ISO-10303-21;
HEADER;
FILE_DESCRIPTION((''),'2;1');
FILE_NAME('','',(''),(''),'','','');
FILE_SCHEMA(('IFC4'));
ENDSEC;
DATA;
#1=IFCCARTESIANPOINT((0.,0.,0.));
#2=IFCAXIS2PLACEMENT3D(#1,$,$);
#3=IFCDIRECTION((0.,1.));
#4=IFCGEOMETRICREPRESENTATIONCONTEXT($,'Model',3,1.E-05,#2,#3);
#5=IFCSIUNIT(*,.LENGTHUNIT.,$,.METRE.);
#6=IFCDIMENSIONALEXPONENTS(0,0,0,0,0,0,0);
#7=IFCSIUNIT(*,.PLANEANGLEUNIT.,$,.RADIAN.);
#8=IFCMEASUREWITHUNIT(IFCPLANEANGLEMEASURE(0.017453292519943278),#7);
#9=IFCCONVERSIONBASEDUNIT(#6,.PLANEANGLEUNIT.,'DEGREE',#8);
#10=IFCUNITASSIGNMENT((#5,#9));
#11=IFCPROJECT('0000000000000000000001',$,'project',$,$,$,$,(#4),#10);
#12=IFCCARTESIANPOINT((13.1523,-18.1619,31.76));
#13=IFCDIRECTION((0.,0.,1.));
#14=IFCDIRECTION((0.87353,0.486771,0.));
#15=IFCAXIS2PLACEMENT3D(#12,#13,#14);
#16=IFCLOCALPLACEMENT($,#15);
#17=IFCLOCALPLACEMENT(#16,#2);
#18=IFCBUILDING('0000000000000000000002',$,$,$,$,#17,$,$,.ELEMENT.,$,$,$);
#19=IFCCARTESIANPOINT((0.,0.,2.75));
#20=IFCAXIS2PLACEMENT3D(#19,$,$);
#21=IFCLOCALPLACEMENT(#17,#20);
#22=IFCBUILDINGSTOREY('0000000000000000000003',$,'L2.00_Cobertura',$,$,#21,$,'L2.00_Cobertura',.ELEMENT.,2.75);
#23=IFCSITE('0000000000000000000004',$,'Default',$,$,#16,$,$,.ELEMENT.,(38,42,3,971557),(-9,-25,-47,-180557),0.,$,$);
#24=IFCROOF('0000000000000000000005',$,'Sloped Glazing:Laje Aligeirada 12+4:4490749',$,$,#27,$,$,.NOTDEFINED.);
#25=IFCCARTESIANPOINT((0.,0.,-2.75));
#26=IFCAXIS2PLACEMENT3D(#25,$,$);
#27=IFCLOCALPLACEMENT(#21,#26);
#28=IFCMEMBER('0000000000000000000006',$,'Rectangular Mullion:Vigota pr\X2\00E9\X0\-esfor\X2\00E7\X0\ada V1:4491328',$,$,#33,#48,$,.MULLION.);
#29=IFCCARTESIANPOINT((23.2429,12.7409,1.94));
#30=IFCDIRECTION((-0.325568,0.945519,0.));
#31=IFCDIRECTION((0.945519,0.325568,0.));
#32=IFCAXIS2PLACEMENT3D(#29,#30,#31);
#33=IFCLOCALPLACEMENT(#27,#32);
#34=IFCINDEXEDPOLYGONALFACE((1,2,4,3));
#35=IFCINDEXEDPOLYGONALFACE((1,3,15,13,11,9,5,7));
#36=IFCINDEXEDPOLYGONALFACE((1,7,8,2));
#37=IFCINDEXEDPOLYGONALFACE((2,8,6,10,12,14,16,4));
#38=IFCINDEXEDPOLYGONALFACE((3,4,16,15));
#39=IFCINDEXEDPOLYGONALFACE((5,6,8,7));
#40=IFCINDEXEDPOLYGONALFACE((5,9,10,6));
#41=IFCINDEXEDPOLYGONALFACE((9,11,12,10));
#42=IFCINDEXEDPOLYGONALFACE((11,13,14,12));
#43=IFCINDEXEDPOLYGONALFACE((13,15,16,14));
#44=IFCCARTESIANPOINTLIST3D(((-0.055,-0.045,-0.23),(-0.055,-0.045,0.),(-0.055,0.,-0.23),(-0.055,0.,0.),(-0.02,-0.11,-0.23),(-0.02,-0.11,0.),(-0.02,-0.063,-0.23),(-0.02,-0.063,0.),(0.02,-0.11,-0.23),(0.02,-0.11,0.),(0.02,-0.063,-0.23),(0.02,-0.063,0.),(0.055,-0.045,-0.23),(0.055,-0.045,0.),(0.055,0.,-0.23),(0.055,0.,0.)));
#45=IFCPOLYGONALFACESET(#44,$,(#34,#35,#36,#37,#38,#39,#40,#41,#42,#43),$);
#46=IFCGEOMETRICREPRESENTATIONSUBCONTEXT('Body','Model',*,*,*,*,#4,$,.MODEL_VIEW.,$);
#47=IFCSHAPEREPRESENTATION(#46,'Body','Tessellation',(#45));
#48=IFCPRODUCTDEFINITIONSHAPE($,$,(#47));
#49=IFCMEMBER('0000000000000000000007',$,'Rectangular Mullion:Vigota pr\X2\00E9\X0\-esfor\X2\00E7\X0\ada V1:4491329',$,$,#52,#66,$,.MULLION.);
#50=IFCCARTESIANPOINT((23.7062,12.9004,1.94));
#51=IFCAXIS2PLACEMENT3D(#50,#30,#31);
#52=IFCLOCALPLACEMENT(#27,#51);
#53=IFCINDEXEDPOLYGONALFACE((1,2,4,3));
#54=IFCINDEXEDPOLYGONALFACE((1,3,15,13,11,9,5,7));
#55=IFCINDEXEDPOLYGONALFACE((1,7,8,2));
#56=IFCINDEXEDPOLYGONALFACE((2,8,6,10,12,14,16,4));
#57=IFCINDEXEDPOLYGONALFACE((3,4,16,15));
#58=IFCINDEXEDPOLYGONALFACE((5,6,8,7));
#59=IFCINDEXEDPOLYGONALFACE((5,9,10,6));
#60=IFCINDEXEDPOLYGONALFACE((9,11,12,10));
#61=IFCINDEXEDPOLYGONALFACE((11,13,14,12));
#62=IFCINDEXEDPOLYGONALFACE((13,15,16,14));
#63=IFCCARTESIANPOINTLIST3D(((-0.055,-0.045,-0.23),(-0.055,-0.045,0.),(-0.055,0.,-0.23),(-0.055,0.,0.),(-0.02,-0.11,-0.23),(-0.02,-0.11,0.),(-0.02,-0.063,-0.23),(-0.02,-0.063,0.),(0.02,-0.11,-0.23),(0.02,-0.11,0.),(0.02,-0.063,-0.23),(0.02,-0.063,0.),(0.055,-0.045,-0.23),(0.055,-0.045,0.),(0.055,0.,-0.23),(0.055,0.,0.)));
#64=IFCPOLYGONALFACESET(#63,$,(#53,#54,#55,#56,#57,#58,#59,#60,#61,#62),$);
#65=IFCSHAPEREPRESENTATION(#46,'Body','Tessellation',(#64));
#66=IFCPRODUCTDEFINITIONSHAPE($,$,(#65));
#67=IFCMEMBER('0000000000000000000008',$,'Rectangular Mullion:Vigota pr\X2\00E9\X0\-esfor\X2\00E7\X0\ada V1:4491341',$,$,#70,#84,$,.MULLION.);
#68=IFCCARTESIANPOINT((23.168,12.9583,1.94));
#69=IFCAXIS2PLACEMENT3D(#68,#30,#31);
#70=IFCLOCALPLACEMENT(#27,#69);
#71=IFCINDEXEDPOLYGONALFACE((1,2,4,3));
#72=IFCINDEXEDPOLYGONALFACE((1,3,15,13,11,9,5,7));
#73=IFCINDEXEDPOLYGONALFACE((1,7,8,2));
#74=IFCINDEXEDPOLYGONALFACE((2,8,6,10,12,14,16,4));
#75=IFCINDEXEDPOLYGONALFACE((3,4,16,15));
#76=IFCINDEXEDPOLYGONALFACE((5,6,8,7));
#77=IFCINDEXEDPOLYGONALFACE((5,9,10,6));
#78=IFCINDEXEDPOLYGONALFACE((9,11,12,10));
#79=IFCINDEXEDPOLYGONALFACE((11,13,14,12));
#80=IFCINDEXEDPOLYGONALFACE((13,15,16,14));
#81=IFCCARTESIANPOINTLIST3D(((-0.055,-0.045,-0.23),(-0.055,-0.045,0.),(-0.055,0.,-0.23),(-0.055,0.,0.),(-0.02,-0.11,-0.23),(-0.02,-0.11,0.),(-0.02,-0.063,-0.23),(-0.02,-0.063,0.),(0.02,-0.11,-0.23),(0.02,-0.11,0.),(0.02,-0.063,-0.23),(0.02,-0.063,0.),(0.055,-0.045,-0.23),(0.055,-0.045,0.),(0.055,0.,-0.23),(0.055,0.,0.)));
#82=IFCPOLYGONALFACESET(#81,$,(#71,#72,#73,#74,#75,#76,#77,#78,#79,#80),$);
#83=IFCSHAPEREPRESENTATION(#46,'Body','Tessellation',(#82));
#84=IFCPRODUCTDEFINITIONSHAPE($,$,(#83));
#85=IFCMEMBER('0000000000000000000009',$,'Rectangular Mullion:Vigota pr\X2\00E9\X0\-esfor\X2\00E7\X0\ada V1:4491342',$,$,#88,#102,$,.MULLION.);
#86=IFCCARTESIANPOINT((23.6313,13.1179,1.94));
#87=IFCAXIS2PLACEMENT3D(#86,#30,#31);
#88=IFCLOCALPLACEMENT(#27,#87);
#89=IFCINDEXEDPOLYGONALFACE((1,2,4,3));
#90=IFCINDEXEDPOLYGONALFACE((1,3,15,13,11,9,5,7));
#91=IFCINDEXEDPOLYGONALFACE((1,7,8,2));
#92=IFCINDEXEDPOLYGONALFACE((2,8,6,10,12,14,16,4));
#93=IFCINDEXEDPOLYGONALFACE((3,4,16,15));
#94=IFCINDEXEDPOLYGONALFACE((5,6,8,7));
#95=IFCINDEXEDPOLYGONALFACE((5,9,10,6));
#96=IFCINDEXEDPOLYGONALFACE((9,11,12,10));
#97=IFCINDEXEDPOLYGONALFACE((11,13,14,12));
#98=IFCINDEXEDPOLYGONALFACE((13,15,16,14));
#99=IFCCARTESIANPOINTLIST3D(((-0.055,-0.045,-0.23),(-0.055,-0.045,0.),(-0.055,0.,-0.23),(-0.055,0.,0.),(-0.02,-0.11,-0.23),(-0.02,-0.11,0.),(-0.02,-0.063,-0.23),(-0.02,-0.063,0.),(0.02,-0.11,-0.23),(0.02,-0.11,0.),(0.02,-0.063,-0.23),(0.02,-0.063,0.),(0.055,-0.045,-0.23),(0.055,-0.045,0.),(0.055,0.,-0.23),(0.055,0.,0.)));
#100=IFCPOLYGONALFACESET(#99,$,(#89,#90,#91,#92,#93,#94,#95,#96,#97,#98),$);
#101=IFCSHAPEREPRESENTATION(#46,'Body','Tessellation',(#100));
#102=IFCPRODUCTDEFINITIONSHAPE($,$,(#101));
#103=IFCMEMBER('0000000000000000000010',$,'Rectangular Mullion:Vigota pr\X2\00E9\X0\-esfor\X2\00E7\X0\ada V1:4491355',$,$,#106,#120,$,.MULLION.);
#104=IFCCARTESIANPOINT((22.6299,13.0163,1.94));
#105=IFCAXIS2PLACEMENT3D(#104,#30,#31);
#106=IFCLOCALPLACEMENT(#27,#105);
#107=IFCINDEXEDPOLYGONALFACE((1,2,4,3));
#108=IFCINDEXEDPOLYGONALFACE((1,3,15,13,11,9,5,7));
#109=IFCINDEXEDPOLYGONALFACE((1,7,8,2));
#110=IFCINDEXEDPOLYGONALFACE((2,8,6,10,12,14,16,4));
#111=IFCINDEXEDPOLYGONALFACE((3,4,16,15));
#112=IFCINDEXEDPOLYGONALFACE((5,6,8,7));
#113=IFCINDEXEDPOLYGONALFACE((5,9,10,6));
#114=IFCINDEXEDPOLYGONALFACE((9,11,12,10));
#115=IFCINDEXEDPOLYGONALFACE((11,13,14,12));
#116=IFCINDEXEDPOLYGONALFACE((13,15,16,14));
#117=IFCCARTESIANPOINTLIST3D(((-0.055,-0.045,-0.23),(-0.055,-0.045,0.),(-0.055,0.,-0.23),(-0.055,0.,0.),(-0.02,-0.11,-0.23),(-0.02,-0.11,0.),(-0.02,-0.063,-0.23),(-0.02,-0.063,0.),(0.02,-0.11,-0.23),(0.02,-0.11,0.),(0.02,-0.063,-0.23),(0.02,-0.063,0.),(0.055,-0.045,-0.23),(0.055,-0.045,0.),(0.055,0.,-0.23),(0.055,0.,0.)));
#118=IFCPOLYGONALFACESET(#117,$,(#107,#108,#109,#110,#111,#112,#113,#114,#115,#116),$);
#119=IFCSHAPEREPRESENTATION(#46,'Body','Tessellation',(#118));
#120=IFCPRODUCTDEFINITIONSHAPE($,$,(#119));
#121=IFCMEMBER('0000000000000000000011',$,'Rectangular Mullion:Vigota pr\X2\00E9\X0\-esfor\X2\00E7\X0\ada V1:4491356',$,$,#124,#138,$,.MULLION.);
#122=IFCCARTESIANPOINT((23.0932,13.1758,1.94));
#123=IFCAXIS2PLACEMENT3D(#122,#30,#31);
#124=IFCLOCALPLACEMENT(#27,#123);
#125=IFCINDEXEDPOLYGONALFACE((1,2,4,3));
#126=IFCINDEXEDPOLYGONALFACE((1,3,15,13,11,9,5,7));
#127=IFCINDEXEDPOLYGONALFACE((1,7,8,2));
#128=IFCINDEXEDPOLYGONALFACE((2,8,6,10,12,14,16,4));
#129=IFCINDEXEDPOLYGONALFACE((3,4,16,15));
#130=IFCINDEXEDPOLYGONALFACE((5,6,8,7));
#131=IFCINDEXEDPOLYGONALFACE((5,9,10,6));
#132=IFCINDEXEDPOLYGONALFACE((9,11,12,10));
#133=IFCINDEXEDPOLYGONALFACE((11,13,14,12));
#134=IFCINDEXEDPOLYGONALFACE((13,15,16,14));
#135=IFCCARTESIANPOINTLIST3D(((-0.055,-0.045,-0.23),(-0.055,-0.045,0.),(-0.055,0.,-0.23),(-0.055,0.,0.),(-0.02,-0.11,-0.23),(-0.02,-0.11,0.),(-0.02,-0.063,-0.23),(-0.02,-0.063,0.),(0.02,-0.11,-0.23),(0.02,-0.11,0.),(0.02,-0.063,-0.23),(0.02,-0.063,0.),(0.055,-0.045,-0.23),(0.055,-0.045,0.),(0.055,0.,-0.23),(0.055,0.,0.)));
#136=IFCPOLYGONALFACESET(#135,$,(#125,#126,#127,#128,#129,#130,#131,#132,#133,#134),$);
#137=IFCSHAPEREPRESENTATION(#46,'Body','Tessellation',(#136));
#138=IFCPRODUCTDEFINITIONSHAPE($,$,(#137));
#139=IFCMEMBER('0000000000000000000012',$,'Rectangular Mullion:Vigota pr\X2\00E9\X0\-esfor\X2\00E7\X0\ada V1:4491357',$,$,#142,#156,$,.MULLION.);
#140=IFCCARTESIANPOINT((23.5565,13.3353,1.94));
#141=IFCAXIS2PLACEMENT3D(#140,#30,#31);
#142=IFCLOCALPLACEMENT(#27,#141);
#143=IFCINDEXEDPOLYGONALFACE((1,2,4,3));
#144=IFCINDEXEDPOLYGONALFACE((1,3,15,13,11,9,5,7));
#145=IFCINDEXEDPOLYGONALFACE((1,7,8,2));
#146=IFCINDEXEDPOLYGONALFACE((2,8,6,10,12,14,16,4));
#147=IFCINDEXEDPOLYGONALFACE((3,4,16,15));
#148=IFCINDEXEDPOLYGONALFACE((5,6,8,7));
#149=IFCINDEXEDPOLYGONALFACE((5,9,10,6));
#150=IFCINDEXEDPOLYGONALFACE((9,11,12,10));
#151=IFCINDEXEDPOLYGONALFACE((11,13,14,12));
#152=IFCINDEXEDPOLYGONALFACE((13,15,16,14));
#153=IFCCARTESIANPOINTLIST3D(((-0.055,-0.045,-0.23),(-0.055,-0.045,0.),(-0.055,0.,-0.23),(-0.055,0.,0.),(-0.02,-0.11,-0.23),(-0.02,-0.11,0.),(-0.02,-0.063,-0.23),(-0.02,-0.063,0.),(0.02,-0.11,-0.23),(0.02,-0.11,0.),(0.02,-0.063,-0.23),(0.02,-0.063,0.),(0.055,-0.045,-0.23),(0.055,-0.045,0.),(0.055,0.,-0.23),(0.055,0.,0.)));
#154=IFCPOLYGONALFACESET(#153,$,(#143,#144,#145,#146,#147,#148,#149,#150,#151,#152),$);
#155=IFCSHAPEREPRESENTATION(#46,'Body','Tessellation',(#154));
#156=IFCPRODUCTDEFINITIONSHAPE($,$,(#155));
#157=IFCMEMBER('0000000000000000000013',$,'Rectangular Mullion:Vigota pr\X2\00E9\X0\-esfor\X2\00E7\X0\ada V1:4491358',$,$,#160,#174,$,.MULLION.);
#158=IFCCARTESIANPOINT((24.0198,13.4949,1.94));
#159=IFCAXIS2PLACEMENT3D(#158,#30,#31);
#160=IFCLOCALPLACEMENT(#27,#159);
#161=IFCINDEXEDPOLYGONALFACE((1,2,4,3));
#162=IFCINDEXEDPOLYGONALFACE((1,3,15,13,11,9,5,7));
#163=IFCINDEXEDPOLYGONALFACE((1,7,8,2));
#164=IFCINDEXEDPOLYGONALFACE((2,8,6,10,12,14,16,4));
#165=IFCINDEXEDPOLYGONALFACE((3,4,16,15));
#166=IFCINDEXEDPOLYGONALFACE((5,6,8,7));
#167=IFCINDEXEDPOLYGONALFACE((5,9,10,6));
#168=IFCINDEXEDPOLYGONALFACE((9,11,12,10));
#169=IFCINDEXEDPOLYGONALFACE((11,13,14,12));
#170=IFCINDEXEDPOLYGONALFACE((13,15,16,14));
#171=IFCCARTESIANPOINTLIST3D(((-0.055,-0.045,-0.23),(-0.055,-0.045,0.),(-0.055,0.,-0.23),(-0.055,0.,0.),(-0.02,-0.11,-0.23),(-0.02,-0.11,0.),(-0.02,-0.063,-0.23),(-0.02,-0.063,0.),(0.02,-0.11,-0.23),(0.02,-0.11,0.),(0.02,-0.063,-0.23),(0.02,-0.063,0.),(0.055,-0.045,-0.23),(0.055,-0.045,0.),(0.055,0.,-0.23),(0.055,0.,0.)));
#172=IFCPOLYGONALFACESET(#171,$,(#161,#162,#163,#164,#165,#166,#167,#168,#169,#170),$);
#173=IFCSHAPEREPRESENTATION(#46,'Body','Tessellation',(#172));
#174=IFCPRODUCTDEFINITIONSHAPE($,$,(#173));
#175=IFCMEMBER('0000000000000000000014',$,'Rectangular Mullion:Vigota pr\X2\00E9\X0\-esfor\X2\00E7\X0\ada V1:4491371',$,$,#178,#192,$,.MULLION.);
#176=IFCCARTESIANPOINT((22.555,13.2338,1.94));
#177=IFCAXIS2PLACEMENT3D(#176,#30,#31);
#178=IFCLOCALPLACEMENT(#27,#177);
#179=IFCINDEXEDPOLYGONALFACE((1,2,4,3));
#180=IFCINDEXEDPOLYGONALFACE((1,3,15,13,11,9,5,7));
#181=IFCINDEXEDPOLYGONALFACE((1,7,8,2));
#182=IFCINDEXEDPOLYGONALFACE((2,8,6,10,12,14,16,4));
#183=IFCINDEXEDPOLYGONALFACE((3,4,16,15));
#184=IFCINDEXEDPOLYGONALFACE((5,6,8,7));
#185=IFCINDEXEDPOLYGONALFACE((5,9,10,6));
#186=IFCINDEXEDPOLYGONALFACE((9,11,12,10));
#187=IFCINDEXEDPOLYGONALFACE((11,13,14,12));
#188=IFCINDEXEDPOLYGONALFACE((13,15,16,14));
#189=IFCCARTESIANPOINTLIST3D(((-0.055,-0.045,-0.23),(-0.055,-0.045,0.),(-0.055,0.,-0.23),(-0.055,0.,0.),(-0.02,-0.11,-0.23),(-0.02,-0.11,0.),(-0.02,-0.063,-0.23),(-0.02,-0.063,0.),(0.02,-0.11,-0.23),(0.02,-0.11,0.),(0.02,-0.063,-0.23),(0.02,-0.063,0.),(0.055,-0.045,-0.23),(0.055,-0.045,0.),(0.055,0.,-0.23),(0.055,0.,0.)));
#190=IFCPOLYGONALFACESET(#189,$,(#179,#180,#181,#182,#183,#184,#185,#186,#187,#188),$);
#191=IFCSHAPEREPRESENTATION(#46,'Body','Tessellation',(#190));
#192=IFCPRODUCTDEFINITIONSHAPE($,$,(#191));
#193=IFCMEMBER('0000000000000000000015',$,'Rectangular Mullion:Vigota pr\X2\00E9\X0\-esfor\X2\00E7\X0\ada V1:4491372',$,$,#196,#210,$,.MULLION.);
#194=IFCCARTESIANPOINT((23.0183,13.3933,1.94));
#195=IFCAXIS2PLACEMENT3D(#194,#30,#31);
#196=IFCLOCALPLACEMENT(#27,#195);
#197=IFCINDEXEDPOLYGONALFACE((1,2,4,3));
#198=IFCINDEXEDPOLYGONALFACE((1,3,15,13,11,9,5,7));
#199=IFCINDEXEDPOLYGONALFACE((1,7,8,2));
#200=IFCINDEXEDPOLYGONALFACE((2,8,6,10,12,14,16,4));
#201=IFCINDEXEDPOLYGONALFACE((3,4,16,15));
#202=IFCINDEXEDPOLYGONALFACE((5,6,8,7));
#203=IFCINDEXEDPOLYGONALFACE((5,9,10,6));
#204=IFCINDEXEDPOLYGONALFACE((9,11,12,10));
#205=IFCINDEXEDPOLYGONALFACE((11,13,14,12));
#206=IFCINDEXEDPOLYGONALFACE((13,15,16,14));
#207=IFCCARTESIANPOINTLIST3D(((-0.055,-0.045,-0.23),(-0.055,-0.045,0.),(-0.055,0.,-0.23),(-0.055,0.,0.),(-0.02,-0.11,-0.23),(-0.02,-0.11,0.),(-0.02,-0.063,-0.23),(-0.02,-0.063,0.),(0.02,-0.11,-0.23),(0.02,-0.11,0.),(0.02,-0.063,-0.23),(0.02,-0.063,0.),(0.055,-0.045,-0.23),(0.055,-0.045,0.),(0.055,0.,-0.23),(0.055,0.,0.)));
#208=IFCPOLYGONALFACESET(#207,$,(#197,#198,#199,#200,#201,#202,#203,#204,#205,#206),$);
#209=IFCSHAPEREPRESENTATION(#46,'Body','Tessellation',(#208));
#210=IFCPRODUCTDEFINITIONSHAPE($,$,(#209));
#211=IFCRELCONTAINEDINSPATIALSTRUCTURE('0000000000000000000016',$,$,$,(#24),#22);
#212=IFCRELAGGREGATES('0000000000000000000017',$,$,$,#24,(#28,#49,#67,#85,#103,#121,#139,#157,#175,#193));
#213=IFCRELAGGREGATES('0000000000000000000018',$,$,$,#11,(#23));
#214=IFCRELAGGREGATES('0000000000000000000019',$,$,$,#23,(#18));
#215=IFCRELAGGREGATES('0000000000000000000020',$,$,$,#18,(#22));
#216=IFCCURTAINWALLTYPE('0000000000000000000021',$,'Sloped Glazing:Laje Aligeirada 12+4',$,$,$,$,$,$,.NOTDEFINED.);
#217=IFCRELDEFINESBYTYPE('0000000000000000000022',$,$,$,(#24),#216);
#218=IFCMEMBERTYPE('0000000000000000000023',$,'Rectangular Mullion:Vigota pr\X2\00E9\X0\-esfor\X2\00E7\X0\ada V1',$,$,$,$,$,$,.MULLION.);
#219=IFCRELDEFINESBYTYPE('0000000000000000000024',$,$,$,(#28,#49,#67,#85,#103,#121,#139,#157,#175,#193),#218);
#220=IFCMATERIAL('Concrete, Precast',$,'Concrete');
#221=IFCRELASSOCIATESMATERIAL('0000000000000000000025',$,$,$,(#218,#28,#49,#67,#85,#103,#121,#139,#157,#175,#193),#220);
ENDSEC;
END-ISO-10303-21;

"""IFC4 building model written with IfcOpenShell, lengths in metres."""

from ifc_helpers import new_model, entity, si_unit, converted_unit, direction, frame, origin, place, context, subcontext, project, spatial, indexed_curve, outline, extrude, source, transform, mapped, material, type_object, type_shapes, element, aggregate, save


model = new_model("IFC4")

# Units and contexts
model_context = context("Model", 3, precision=1e-05, world=origin(), true_north=direction((0.0, 1.0)))
body_context = subcontext(model_context, "Body", "Model", "MODEL_VIEW")
ifc_project = project(units=[si_unit("LENGTHUNIT", "METRE"), converted_unit("PLANEANGLEUNIT", "DEGREE", entity("IfcPlaneAngleMeasure", 0.017453292519943278), si_unit("PLANEANGLEUNIT", "RADIAN"), dimensions=[0, 0, 0, 0, 0, 0, 0])], contexts=[model_context])

# Site, building, storey
site_placement = place(None, frame((13.1523, -18.1619, 31.76), z_axis=(0.0, 0.0, 1.0), x_axis=(0.87353, 0.486771, 0.0)))
site = spatial("IfcSite", under=ifc_project, at=site_placement, Name="Default", CompositionType="ELEMENT", RefLatitude=(38, 42, 3, 971557), RefLongitude=(-9, -25, -47, -180557), RefElevation=0.0)
building_placement = place(site_placement, origin())
building = spatial("IfcBuilding", under=site, at=building_placement, CompositionType="ELEMENT")
storey_placement = place(building_placement, frame((0.0, 0.0, 2.75)))
storey = spatial("IfcBuildingStorey", under=building, at=storey_placement, Name="L2.00_Cobertura", LongName="L2.00_Cobertura", CompositionType="ELEMENT", Elevation=2.75)

# Roof, members
curtain_wall_type = type_object("IfcCurtainWallType", Name="Sloped Glazing:Laje Aligeirada 12+4", PredefinedType="NOTDEFINED")
roof_placement = place(storey_placement, frame((0.0, 0.0, -2.75)))
roof = element("IfcRoof", 1, at=roof_placement, inside=storey, type_object=curtain_wall_type, Name="Sloped Glazing:Laje Aligeirada 12+4:4490749", PredefinedType="NOTDEFINED")
ifc_material_1 = material(Name="Concrete, Precast", Category="Concrete")
member_type = type_object("IfcMemberType", Name="Rectangular Mullion:Vigota pré-esforçada V1", PredefinedType="MULLION", material=ifc_material_1)
shared_shape_1 = source(origin(), body_context, "Body", "SweptSolid", [
    extrude(outline(indexed_curve([(-0.055, -0.0545), (0.055, -0.0545), (0.055, -0.0095), (0.02, 0.0085), (0.02, 0.0555), (-0.02, 0.0555), (-0.02, 0.0085), (-0.055, -0.0095), (-0.055, -0.0545)], self_intersect=False)), frame((0.0, -0.0545, -0.23), z_axis=(0.0, 0.0, 1.0), x_axis=(-1.0, 0.0, 0.0)), (0.0, 0.0, 1.0), 0.23),
])
type_shapes(member_type, [shared_shape_1])
member_1_placement = place(roof_placement, frame((23.2429, 12.7409, 1.94), z_axis=(-0.325568, 0.945519, 0.0), x_axis=(0.945519, 0.325568, 0.0)))
member_1 = element("IfcMember", 2, at=member_1_placement, type_object=member_type, material=ifc_material_1, Name="Rectangular Mullion:Vigota pré-esforçada V1:4491328", PredefinedType="MULLION", context=body_context, shape_type="MappedRepresentation", body=[
    mapped(shared_shape_1, transform((0.0, 0.0, 0.0), scale=1.0)),
])
member_2_placement = place(roof_placement, frame((23.7062, 12.9004, 1.94), z_axis=(-0.325568, 0.945519, 0.0), x_axis=(0.945519, 0.325568, 0.0)))
member_2 = element("IfcMember", 3, at=member_2_placement, type_object=member_type, material=ifc_material_1, Name="Rectangular Mullion:Vigota pré-esforçada V1:4491329", PredefinedType="MULLION", context=body_context, shape_type="MappedRepresentation", body=[
    mapped(shared_shape_1, transform((0.0, 0.0, 0.0), scale=1.0)),
])
member_3_placement = place(roof_placement, frame((23.168, 12.9583, 1.94), z_axis=(-0.325568, 0.945519, 0.0), x_axis=(0.945519, 0.325568, 0.0)))
member_3 = element("IfcMember", 4, at=member_3_placement, type_object=member_type, material=ifc_material_1, Name="Rectangular Mullion:Vigota pré-esforçada V1:4491341", PredefinedType="MULLION", context=body_context, shape_type="MappedRepresentation", body=[
    mapped(shared_shape_1, transform((0.0, 0.0, 0.0), scale=1.0)),
])
member_4_placement = place(roof_placement, frame((23.6313, 13.1179, 1.94), z_axis=(-0.325568, 0.945519, 0.0), x_axis=(0.945519, 0.325568, 0.0)))
member_4 = element("IfcMember", 5, at=member_4_placement, type_object=member_type, material=ifc_material_1, Name="Rectangular Mullion:Vigota pré-esforçada V1:4491342", PredefinedType="MULLION", context=body_context, shape_type="MappedRepresentation", body=[
    mapped(shared_shape_1, transform((0.0, 0.0, 0.0), scale=1.0)),
])
member_5_placement = place(roof_placement, frame((22.6299, 13.0163, 1.94), z_axis=(-0.325568, 0.945519, 0.0), x_axis=(0.945519, 0.325568, 0.0)))
member_5 = element("IfcMember", 6, at=member_5_placement, type_object=member_type, material=ifc_material_1, Name="Rectangular Mullion:Vigota pré-esforçada V1:4491355", PredefinedType="MULLION", context=body_context, shape_type="MappedRepresentation", body=[
    mapped(shared_shape_1, transform((0.0, 0.0, 0.0), scale=1.0)),
])
member_6_placement = place(roof_placement, frame((23.0932, 13.1758, 1.94), z_axis=(-0.325568, 0.945519, 0.0), x_axis=(0.945519, 0.325568, 0.0)))
member_6 = element("IfcMember", 7, at=member_6_placement, type_object=member_type, material=ifc_material_1, Name="Rectangular Mullion:Vigota pré-esforçada V1:4491356", PredefinedType="MULLION", context=body_context, shape_type="MappedRepresentation", body=[
    mapped(shared_shape_1, transform((0.0, 0.0, 0.0), scale=1.0)),
])
member_7_placement = place(roof_placement, frame((23.5565, 13.3353, 1.94), z_axis=(-0.325568, 0.945519, 0.0), x_axis=(0.945519, 0.325568, 0.0)))
member_7 = element("IfcMember", 8, at=member_7_placement, type_object=member_type, material=ifc_material_1, Name="Rectangular Mullion:Vigota pré-esforçada V1:4491357", PredefinedType="MULLION", context=body_context, shape_type="MappedRepresentation", body=[
    mapped(shared_shape_1, transform((0.0, 0.0, 0.0), scale=1.0)),
])
member_8_placement = place(roof_placement, frame((24.0198, 13.4949, 1.94), z_axis=(-0.325568, 0.945519, 0.0), x_axis=(0.945519, 0.325568, 0.0)))
member_8 = element("IfcMember", 9, at=member_8_placement, type_object=member_type, material=ifc_material_1, Name="Rectangular Mullion:Vigota pré-esforçada V1:4491358", PredefinedType="MULLION", context=body_context, shape_type="MappedRepresentation", body=[
    mapped(shared_shape_1, transform((0.0, 0.0, 0.0), scale=1.0)),
])
member_9_placement = place(roof_placement, frame((22.555, 13.2338, 1.94), z_axis=(-0.325568, 0.945519, 0.0), x_axis=(0.945519, 0.325568, 0.0)))
member_9 = element("IfcMember", 10, at=member_9_placement, type_object=member_type, material=ifc_material_1, Name="Rectangular Mullion:Vigota pré-esforçada V1:4491371", PredefinedType="MULLION", context=body_context, shape_type="MappedRepresentation", body=[
    mapped(shared_shape_1, transform((0.0, 0.0, 0.0), scale=1.0)),
])
member_10_placement = place(roof_placement, frame((23.0183, 13.3933, 1.94), z_axis=(-0.325568, 0.945519, 0.0), x_axis=(0.945519, 0.325568, 0.0)))
member_10 = element("IfcMember", 11, at=member_10_placement, type_object=member_type, material=ifc_material_1, Name="Rectangular Mullion:Vigota pré-esforçada V1:4491372", PredefinedType="MULLION", context=body_context, shape_type="MappedRepresentation", body=[
    mapped(shared_shape_1, transform((0.0, 0.0, 0.0), scale=1.0)),
])
aggregate(roof, [member_1, member_2, member_3, member_4, member_5, member_6, member_7, member_8, member_9, member_10])

save(model, "model.ifc")
